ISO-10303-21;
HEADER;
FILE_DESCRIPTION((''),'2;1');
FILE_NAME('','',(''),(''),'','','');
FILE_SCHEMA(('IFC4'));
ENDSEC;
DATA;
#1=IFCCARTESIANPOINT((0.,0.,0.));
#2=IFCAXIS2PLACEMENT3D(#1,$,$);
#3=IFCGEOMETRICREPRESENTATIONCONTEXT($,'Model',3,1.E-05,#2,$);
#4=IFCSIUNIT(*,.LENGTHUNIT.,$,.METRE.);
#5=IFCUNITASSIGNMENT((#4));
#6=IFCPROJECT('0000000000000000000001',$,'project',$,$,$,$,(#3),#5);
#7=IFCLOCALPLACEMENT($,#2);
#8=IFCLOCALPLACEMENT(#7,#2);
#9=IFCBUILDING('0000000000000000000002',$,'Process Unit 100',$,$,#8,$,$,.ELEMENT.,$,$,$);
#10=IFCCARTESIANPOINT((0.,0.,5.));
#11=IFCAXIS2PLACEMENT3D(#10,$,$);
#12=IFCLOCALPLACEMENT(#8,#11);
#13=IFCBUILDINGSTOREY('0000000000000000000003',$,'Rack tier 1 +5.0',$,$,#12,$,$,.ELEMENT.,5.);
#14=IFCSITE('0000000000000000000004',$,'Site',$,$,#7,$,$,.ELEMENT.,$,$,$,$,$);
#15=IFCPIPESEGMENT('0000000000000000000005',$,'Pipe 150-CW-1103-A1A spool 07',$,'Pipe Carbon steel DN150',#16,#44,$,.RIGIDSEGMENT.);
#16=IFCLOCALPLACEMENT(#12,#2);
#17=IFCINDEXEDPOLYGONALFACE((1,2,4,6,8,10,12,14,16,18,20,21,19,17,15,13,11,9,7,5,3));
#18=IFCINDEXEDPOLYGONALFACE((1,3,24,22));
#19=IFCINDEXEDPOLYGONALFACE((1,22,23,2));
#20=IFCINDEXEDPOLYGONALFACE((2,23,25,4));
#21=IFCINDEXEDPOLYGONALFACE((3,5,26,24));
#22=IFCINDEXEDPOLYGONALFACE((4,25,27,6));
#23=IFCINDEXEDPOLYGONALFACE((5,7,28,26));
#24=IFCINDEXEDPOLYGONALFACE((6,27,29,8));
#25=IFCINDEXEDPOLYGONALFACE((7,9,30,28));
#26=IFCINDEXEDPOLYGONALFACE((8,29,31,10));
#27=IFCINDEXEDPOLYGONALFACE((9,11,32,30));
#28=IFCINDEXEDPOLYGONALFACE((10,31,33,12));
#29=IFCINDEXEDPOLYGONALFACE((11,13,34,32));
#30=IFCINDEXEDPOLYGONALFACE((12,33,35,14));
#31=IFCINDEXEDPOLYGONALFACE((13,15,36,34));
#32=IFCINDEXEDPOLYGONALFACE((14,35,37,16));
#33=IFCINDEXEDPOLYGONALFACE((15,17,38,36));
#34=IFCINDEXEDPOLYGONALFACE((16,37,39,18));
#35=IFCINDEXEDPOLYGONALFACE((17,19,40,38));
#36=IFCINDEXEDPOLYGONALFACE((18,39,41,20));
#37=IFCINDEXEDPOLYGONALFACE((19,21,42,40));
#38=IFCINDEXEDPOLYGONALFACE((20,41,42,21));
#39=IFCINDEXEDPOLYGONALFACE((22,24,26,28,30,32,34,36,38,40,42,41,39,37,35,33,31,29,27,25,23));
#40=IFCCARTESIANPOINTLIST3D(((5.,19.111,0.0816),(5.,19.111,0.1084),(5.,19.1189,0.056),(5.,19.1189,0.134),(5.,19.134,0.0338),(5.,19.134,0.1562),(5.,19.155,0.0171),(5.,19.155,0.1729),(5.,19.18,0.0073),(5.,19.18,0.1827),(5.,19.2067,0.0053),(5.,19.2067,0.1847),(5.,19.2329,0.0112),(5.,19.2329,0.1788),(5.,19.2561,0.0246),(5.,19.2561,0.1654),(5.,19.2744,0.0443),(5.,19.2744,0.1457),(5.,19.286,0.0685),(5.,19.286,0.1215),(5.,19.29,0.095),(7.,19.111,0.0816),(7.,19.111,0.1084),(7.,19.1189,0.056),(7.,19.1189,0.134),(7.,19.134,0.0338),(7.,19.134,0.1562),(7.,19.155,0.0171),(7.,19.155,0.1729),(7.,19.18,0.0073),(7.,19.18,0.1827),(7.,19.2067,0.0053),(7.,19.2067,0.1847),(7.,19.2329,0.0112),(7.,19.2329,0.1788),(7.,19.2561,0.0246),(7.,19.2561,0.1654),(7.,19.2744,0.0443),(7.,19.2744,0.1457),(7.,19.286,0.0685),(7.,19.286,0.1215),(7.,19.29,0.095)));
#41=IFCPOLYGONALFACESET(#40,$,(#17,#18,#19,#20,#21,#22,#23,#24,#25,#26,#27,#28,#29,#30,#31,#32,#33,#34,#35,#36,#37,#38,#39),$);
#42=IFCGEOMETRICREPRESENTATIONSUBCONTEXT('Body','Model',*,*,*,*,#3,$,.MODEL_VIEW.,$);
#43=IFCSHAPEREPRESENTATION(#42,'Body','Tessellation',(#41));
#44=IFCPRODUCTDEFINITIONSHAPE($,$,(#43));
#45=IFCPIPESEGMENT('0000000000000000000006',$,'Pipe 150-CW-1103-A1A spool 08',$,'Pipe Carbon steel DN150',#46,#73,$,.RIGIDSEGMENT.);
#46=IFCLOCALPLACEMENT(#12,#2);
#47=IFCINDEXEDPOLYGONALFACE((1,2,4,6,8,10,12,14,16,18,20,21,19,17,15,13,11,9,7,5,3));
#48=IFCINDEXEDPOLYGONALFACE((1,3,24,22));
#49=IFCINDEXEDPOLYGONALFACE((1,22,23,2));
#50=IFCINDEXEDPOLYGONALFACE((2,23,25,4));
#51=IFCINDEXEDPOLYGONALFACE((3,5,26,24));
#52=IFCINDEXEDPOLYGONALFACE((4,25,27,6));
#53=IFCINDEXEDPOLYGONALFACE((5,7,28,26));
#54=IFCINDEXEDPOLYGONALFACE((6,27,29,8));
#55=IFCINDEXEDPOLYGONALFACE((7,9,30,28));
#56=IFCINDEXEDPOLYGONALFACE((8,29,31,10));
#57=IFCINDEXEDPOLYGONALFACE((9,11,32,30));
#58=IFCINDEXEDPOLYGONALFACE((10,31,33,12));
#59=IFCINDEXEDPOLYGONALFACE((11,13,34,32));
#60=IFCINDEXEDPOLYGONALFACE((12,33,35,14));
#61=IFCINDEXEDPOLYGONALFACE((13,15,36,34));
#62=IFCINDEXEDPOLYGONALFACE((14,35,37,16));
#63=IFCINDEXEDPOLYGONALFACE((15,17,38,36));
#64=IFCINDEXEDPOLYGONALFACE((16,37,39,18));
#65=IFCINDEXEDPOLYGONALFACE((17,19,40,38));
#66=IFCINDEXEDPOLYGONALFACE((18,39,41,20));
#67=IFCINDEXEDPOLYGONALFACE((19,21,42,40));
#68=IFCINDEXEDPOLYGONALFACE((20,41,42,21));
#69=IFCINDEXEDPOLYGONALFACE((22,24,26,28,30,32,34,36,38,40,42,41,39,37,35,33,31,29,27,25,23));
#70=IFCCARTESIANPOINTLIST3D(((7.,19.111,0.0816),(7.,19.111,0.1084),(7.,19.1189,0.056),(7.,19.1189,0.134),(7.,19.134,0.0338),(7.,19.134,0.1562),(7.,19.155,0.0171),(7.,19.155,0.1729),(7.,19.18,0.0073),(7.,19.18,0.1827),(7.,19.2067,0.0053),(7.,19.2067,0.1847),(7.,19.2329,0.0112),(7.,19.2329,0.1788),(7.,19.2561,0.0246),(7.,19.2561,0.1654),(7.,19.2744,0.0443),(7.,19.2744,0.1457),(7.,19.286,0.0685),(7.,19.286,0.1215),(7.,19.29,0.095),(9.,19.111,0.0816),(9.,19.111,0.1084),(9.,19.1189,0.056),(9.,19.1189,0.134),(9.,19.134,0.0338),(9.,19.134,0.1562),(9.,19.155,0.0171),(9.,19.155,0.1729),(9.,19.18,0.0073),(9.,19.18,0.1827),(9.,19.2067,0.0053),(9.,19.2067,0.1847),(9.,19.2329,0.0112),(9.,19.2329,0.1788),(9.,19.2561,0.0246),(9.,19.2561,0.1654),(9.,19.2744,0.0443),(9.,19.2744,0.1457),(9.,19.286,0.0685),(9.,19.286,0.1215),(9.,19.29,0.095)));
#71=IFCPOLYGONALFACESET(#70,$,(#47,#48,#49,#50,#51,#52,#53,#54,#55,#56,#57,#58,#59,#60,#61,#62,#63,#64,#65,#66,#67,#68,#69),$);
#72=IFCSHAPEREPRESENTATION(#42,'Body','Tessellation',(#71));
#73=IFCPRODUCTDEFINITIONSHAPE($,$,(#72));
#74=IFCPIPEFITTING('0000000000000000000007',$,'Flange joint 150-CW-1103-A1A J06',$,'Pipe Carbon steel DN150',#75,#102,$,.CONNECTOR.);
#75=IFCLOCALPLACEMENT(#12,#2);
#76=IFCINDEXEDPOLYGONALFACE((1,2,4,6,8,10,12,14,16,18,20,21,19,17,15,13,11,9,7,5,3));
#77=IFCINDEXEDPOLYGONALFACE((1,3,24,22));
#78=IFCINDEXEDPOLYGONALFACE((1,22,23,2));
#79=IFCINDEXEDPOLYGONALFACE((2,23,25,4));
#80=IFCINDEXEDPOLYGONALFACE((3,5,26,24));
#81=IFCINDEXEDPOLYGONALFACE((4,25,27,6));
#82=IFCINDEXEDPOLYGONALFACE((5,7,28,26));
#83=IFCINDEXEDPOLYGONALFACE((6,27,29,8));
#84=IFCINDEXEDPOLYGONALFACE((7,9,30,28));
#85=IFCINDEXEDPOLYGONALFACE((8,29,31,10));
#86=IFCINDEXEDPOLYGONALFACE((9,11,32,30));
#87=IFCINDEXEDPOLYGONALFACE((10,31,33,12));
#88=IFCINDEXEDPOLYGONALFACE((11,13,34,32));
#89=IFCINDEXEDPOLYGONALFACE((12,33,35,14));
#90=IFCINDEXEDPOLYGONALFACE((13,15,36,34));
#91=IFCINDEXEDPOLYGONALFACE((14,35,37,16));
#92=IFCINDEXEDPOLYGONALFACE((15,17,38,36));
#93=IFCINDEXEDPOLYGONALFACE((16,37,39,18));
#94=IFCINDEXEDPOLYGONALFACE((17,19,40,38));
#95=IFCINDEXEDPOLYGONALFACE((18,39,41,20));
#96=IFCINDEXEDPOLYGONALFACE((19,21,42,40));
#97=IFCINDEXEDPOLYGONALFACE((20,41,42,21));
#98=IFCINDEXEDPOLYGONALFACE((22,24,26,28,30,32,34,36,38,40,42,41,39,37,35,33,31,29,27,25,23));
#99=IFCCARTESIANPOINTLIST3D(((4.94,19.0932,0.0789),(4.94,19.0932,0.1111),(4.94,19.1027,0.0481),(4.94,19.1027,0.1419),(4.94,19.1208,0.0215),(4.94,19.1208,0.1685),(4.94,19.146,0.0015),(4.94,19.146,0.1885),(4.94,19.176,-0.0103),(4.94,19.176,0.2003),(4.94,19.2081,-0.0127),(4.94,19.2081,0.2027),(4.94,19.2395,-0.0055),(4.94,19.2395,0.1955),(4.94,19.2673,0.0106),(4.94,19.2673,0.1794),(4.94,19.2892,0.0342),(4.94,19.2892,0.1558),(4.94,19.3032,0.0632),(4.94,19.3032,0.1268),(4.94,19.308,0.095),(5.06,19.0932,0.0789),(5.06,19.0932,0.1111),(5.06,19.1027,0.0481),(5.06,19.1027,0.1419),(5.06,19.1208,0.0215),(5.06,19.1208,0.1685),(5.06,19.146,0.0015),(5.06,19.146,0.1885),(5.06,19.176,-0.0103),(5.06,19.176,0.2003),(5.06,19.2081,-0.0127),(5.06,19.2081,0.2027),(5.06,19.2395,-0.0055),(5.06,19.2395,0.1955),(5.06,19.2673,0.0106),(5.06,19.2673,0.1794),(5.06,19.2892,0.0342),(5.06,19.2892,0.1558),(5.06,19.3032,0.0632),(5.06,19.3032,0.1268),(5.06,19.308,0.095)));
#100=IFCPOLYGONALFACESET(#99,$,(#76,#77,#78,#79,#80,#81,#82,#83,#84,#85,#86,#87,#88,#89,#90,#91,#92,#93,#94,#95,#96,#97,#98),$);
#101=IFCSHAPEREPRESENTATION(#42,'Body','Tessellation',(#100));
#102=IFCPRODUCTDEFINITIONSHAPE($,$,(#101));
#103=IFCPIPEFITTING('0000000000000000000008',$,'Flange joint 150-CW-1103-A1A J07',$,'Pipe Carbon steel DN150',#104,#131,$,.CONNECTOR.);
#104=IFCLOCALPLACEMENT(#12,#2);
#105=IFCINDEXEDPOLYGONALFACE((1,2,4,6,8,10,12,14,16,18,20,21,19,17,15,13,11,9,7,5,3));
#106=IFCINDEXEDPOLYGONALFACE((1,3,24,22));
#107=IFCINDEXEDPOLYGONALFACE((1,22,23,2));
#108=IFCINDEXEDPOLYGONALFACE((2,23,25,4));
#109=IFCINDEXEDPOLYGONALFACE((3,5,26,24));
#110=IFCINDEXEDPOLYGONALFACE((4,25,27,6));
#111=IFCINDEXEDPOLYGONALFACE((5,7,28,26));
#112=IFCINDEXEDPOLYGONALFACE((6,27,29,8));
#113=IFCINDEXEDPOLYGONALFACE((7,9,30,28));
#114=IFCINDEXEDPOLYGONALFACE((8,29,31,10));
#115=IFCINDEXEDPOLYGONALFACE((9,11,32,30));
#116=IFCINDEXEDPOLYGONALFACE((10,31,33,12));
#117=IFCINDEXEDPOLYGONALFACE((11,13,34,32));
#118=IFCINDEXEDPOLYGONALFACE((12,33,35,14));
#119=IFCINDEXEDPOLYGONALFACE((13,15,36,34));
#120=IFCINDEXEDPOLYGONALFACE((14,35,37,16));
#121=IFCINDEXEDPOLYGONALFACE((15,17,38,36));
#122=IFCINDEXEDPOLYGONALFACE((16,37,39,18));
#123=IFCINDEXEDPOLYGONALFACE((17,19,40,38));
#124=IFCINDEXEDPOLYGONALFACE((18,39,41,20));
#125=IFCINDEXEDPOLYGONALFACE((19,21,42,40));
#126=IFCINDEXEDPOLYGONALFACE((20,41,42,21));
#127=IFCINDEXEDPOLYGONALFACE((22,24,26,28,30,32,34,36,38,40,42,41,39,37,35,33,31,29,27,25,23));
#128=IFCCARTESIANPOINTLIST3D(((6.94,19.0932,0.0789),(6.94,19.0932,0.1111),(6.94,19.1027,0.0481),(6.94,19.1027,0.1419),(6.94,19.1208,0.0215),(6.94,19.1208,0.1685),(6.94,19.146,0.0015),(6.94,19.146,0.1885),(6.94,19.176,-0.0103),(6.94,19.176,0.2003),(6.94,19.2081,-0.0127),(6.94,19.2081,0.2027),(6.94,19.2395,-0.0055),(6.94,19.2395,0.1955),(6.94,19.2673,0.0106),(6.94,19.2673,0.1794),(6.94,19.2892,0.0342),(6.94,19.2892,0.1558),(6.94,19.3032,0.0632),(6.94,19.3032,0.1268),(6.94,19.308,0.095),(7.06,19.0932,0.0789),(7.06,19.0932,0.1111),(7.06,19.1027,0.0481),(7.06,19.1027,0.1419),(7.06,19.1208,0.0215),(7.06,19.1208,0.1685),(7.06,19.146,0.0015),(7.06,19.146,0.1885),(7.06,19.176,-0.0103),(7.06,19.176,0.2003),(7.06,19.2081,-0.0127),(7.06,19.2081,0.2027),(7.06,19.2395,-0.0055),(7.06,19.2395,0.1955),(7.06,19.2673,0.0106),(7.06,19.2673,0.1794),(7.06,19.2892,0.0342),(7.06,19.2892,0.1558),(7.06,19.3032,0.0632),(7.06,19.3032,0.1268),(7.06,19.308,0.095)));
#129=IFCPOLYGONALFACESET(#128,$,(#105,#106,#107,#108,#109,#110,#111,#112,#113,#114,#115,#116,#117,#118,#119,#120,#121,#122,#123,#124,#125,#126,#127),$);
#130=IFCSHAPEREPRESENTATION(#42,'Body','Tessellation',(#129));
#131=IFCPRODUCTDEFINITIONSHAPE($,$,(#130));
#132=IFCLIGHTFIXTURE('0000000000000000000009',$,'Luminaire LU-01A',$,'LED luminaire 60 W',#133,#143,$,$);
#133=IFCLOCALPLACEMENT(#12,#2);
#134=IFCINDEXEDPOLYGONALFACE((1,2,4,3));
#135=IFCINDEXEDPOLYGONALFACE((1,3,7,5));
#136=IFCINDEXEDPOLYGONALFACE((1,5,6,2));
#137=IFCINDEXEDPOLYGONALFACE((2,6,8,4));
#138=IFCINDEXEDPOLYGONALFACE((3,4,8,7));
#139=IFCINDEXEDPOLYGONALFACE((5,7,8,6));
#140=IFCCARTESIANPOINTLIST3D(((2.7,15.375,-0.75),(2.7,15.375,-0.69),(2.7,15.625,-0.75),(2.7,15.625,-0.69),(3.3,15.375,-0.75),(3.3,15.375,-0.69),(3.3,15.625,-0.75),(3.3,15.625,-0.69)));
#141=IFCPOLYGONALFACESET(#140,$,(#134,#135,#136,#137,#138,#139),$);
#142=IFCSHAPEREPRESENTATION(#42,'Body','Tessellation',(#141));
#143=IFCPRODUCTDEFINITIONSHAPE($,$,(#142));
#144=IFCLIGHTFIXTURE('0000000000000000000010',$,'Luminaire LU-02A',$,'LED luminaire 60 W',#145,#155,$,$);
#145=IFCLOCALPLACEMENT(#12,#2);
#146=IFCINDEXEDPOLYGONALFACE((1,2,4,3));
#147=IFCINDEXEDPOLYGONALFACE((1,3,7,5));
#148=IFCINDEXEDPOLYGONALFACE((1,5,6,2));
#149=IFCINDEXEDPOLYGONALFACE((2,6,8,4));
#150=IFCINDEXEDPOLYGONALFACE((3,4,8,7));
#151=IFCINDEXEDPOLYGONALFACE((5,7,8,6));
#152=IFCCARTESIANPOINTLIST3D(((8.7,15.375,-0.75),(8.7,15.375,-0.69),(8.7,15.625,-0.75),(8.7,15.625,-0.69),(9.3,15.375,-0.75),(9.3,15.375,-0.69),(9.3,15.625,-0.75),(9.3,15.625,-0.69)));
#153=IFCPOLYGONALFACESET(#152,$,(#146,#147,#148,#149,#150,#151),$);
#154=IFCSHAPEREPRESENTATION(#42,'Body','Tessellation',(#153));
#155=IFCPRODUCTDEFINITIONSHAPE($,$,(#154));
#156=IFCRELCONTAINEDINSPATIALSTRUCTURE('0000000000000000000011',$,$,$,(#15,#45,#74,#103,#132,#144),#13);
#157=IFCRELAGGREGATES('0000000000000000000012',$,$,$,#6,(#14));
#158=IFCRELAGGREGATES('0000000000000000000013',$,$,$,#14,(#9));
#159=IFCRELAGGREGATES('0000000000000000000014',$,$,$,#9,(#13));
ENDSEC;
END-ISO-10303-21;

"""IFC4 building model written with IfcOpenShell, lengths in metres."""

from ifc_helpers import new_model, si_unit, frame, origin, place, context, subcontext, project, spatial, rectangle, circle, extrude, element, save


model = new_model("IFC4")

# Units and contexts
model_context = context("Model", 3, precision=1e-05, world=origin())
body_context = subcontext(model_context, "Body", "Model", "MODEL_VIEW")
ifc_project = project(units=[si_unit("LENGTHUNIT", "METRE")], contexts=[model_context])

# Site, building, storey
site_placement = place(None, origin())
site = spatial("IfcSite", under=ifc_project, at=site_placement, Name="Site", CompositionType="ELEMENT")
building_placement = place(site_placement, origin())
building = spatial("IfcBuilding", under=site, at=building_placement, Name="Process Unit 100", CompositionType="ELEMENT")
storey_placement = place(building_placement, frame((0.0, 0.0, 5.0)))
storey = spatial("IfcBuildingStorey", under=building, at=storey_placement, Name="Rack tier 1 +5.0", CompositionType="ELEMENT", Elevation=5.0)

# Pipe segments
for number, where, z_axis, x_axis, name in (
    (1, (5.0, 19.2, 0.095), (1.0, 0.0, 0.0), (0.0, 1.0, 0.0), "Pipe 150-CW-1103-A1A spool 07"),
    (2, (7.0, 19.2, 0.095), (1.0, 0.0, 0.0), (0.0, 1.0, 0.0), "Pipe 150-CW-1103-A1A spool 08"),
):
    element("IfcPipeSegment", number, at=place(storey_placement, frame(where, z_axis=z_axis, x_axis=x_axis)), inside=storey, Name=name, ObjectType="Pipe Carbon steel DN150", PredefinedType="RIGIDSEGMENT", context=body_context, shape_type="SweptSolid", body=[
        extrude(circle(Radius=0.09), origin(), (0.0, 0.0, 1.0), 2.0),
    ])

# Pipe fittings
for number, where, z_axis, x_axis, name in (
    (3, (4.94, 19.2, 0.095), (1.0, 0.0, 0.0), (0.0, 1.0, 0.0), "Flange joint 150-CW-1103-A1A J06"),
    (4, (6.94, 19.2, 0.095), (1.0, 0.0, 0.0), (0.0, 1.0, 0.0), "Flange joint 150-CW-1103-A1A J07"),
):
    element("IfcPipeFitting", number, at=place(storey_placement, frame(where, z_axis=z_axis, x_axis=x_axis)), inside=storey, Name=name, ObjectType="Pipe Carbon steel DN150", PredefinedType="CONNECTOR", context=body_context, shape_type="SweptSolid", body=[
        extrude(circle(Radius=0.108), origin(), (0.0, 0.0, 1.0), 0.12),
    ])

# Light fixtures
for number, where, z_axis, x_axis, name in (
    (5, (3.0, 15.5, -0.75), (0.0, 0.0, 1.0), (1.0, 0.0, 0.0), "Luminaire LU-01A"),
    (6, (9.0, 15.5, -0.75), (0.0, 0.0, 1.0), (1.0, 0.0, 0.0), "Luminaire LU-02A"),
):
    element("IfcLightFixture", number, at=place(storey_placement, frame(where, z_axis=z_axis, x_axis=x_axis)), inside=storey, Name=name, ObjectType="LED luminaire 60 W", context=body_context, shape_type="SweptSolid", body=[
        extrude(rectangle(XDim=0.6, YDim=0.25), origin(), (0.0, 0.0, 1.0), 0.06),
    ])

save(model, "model.ifc")
